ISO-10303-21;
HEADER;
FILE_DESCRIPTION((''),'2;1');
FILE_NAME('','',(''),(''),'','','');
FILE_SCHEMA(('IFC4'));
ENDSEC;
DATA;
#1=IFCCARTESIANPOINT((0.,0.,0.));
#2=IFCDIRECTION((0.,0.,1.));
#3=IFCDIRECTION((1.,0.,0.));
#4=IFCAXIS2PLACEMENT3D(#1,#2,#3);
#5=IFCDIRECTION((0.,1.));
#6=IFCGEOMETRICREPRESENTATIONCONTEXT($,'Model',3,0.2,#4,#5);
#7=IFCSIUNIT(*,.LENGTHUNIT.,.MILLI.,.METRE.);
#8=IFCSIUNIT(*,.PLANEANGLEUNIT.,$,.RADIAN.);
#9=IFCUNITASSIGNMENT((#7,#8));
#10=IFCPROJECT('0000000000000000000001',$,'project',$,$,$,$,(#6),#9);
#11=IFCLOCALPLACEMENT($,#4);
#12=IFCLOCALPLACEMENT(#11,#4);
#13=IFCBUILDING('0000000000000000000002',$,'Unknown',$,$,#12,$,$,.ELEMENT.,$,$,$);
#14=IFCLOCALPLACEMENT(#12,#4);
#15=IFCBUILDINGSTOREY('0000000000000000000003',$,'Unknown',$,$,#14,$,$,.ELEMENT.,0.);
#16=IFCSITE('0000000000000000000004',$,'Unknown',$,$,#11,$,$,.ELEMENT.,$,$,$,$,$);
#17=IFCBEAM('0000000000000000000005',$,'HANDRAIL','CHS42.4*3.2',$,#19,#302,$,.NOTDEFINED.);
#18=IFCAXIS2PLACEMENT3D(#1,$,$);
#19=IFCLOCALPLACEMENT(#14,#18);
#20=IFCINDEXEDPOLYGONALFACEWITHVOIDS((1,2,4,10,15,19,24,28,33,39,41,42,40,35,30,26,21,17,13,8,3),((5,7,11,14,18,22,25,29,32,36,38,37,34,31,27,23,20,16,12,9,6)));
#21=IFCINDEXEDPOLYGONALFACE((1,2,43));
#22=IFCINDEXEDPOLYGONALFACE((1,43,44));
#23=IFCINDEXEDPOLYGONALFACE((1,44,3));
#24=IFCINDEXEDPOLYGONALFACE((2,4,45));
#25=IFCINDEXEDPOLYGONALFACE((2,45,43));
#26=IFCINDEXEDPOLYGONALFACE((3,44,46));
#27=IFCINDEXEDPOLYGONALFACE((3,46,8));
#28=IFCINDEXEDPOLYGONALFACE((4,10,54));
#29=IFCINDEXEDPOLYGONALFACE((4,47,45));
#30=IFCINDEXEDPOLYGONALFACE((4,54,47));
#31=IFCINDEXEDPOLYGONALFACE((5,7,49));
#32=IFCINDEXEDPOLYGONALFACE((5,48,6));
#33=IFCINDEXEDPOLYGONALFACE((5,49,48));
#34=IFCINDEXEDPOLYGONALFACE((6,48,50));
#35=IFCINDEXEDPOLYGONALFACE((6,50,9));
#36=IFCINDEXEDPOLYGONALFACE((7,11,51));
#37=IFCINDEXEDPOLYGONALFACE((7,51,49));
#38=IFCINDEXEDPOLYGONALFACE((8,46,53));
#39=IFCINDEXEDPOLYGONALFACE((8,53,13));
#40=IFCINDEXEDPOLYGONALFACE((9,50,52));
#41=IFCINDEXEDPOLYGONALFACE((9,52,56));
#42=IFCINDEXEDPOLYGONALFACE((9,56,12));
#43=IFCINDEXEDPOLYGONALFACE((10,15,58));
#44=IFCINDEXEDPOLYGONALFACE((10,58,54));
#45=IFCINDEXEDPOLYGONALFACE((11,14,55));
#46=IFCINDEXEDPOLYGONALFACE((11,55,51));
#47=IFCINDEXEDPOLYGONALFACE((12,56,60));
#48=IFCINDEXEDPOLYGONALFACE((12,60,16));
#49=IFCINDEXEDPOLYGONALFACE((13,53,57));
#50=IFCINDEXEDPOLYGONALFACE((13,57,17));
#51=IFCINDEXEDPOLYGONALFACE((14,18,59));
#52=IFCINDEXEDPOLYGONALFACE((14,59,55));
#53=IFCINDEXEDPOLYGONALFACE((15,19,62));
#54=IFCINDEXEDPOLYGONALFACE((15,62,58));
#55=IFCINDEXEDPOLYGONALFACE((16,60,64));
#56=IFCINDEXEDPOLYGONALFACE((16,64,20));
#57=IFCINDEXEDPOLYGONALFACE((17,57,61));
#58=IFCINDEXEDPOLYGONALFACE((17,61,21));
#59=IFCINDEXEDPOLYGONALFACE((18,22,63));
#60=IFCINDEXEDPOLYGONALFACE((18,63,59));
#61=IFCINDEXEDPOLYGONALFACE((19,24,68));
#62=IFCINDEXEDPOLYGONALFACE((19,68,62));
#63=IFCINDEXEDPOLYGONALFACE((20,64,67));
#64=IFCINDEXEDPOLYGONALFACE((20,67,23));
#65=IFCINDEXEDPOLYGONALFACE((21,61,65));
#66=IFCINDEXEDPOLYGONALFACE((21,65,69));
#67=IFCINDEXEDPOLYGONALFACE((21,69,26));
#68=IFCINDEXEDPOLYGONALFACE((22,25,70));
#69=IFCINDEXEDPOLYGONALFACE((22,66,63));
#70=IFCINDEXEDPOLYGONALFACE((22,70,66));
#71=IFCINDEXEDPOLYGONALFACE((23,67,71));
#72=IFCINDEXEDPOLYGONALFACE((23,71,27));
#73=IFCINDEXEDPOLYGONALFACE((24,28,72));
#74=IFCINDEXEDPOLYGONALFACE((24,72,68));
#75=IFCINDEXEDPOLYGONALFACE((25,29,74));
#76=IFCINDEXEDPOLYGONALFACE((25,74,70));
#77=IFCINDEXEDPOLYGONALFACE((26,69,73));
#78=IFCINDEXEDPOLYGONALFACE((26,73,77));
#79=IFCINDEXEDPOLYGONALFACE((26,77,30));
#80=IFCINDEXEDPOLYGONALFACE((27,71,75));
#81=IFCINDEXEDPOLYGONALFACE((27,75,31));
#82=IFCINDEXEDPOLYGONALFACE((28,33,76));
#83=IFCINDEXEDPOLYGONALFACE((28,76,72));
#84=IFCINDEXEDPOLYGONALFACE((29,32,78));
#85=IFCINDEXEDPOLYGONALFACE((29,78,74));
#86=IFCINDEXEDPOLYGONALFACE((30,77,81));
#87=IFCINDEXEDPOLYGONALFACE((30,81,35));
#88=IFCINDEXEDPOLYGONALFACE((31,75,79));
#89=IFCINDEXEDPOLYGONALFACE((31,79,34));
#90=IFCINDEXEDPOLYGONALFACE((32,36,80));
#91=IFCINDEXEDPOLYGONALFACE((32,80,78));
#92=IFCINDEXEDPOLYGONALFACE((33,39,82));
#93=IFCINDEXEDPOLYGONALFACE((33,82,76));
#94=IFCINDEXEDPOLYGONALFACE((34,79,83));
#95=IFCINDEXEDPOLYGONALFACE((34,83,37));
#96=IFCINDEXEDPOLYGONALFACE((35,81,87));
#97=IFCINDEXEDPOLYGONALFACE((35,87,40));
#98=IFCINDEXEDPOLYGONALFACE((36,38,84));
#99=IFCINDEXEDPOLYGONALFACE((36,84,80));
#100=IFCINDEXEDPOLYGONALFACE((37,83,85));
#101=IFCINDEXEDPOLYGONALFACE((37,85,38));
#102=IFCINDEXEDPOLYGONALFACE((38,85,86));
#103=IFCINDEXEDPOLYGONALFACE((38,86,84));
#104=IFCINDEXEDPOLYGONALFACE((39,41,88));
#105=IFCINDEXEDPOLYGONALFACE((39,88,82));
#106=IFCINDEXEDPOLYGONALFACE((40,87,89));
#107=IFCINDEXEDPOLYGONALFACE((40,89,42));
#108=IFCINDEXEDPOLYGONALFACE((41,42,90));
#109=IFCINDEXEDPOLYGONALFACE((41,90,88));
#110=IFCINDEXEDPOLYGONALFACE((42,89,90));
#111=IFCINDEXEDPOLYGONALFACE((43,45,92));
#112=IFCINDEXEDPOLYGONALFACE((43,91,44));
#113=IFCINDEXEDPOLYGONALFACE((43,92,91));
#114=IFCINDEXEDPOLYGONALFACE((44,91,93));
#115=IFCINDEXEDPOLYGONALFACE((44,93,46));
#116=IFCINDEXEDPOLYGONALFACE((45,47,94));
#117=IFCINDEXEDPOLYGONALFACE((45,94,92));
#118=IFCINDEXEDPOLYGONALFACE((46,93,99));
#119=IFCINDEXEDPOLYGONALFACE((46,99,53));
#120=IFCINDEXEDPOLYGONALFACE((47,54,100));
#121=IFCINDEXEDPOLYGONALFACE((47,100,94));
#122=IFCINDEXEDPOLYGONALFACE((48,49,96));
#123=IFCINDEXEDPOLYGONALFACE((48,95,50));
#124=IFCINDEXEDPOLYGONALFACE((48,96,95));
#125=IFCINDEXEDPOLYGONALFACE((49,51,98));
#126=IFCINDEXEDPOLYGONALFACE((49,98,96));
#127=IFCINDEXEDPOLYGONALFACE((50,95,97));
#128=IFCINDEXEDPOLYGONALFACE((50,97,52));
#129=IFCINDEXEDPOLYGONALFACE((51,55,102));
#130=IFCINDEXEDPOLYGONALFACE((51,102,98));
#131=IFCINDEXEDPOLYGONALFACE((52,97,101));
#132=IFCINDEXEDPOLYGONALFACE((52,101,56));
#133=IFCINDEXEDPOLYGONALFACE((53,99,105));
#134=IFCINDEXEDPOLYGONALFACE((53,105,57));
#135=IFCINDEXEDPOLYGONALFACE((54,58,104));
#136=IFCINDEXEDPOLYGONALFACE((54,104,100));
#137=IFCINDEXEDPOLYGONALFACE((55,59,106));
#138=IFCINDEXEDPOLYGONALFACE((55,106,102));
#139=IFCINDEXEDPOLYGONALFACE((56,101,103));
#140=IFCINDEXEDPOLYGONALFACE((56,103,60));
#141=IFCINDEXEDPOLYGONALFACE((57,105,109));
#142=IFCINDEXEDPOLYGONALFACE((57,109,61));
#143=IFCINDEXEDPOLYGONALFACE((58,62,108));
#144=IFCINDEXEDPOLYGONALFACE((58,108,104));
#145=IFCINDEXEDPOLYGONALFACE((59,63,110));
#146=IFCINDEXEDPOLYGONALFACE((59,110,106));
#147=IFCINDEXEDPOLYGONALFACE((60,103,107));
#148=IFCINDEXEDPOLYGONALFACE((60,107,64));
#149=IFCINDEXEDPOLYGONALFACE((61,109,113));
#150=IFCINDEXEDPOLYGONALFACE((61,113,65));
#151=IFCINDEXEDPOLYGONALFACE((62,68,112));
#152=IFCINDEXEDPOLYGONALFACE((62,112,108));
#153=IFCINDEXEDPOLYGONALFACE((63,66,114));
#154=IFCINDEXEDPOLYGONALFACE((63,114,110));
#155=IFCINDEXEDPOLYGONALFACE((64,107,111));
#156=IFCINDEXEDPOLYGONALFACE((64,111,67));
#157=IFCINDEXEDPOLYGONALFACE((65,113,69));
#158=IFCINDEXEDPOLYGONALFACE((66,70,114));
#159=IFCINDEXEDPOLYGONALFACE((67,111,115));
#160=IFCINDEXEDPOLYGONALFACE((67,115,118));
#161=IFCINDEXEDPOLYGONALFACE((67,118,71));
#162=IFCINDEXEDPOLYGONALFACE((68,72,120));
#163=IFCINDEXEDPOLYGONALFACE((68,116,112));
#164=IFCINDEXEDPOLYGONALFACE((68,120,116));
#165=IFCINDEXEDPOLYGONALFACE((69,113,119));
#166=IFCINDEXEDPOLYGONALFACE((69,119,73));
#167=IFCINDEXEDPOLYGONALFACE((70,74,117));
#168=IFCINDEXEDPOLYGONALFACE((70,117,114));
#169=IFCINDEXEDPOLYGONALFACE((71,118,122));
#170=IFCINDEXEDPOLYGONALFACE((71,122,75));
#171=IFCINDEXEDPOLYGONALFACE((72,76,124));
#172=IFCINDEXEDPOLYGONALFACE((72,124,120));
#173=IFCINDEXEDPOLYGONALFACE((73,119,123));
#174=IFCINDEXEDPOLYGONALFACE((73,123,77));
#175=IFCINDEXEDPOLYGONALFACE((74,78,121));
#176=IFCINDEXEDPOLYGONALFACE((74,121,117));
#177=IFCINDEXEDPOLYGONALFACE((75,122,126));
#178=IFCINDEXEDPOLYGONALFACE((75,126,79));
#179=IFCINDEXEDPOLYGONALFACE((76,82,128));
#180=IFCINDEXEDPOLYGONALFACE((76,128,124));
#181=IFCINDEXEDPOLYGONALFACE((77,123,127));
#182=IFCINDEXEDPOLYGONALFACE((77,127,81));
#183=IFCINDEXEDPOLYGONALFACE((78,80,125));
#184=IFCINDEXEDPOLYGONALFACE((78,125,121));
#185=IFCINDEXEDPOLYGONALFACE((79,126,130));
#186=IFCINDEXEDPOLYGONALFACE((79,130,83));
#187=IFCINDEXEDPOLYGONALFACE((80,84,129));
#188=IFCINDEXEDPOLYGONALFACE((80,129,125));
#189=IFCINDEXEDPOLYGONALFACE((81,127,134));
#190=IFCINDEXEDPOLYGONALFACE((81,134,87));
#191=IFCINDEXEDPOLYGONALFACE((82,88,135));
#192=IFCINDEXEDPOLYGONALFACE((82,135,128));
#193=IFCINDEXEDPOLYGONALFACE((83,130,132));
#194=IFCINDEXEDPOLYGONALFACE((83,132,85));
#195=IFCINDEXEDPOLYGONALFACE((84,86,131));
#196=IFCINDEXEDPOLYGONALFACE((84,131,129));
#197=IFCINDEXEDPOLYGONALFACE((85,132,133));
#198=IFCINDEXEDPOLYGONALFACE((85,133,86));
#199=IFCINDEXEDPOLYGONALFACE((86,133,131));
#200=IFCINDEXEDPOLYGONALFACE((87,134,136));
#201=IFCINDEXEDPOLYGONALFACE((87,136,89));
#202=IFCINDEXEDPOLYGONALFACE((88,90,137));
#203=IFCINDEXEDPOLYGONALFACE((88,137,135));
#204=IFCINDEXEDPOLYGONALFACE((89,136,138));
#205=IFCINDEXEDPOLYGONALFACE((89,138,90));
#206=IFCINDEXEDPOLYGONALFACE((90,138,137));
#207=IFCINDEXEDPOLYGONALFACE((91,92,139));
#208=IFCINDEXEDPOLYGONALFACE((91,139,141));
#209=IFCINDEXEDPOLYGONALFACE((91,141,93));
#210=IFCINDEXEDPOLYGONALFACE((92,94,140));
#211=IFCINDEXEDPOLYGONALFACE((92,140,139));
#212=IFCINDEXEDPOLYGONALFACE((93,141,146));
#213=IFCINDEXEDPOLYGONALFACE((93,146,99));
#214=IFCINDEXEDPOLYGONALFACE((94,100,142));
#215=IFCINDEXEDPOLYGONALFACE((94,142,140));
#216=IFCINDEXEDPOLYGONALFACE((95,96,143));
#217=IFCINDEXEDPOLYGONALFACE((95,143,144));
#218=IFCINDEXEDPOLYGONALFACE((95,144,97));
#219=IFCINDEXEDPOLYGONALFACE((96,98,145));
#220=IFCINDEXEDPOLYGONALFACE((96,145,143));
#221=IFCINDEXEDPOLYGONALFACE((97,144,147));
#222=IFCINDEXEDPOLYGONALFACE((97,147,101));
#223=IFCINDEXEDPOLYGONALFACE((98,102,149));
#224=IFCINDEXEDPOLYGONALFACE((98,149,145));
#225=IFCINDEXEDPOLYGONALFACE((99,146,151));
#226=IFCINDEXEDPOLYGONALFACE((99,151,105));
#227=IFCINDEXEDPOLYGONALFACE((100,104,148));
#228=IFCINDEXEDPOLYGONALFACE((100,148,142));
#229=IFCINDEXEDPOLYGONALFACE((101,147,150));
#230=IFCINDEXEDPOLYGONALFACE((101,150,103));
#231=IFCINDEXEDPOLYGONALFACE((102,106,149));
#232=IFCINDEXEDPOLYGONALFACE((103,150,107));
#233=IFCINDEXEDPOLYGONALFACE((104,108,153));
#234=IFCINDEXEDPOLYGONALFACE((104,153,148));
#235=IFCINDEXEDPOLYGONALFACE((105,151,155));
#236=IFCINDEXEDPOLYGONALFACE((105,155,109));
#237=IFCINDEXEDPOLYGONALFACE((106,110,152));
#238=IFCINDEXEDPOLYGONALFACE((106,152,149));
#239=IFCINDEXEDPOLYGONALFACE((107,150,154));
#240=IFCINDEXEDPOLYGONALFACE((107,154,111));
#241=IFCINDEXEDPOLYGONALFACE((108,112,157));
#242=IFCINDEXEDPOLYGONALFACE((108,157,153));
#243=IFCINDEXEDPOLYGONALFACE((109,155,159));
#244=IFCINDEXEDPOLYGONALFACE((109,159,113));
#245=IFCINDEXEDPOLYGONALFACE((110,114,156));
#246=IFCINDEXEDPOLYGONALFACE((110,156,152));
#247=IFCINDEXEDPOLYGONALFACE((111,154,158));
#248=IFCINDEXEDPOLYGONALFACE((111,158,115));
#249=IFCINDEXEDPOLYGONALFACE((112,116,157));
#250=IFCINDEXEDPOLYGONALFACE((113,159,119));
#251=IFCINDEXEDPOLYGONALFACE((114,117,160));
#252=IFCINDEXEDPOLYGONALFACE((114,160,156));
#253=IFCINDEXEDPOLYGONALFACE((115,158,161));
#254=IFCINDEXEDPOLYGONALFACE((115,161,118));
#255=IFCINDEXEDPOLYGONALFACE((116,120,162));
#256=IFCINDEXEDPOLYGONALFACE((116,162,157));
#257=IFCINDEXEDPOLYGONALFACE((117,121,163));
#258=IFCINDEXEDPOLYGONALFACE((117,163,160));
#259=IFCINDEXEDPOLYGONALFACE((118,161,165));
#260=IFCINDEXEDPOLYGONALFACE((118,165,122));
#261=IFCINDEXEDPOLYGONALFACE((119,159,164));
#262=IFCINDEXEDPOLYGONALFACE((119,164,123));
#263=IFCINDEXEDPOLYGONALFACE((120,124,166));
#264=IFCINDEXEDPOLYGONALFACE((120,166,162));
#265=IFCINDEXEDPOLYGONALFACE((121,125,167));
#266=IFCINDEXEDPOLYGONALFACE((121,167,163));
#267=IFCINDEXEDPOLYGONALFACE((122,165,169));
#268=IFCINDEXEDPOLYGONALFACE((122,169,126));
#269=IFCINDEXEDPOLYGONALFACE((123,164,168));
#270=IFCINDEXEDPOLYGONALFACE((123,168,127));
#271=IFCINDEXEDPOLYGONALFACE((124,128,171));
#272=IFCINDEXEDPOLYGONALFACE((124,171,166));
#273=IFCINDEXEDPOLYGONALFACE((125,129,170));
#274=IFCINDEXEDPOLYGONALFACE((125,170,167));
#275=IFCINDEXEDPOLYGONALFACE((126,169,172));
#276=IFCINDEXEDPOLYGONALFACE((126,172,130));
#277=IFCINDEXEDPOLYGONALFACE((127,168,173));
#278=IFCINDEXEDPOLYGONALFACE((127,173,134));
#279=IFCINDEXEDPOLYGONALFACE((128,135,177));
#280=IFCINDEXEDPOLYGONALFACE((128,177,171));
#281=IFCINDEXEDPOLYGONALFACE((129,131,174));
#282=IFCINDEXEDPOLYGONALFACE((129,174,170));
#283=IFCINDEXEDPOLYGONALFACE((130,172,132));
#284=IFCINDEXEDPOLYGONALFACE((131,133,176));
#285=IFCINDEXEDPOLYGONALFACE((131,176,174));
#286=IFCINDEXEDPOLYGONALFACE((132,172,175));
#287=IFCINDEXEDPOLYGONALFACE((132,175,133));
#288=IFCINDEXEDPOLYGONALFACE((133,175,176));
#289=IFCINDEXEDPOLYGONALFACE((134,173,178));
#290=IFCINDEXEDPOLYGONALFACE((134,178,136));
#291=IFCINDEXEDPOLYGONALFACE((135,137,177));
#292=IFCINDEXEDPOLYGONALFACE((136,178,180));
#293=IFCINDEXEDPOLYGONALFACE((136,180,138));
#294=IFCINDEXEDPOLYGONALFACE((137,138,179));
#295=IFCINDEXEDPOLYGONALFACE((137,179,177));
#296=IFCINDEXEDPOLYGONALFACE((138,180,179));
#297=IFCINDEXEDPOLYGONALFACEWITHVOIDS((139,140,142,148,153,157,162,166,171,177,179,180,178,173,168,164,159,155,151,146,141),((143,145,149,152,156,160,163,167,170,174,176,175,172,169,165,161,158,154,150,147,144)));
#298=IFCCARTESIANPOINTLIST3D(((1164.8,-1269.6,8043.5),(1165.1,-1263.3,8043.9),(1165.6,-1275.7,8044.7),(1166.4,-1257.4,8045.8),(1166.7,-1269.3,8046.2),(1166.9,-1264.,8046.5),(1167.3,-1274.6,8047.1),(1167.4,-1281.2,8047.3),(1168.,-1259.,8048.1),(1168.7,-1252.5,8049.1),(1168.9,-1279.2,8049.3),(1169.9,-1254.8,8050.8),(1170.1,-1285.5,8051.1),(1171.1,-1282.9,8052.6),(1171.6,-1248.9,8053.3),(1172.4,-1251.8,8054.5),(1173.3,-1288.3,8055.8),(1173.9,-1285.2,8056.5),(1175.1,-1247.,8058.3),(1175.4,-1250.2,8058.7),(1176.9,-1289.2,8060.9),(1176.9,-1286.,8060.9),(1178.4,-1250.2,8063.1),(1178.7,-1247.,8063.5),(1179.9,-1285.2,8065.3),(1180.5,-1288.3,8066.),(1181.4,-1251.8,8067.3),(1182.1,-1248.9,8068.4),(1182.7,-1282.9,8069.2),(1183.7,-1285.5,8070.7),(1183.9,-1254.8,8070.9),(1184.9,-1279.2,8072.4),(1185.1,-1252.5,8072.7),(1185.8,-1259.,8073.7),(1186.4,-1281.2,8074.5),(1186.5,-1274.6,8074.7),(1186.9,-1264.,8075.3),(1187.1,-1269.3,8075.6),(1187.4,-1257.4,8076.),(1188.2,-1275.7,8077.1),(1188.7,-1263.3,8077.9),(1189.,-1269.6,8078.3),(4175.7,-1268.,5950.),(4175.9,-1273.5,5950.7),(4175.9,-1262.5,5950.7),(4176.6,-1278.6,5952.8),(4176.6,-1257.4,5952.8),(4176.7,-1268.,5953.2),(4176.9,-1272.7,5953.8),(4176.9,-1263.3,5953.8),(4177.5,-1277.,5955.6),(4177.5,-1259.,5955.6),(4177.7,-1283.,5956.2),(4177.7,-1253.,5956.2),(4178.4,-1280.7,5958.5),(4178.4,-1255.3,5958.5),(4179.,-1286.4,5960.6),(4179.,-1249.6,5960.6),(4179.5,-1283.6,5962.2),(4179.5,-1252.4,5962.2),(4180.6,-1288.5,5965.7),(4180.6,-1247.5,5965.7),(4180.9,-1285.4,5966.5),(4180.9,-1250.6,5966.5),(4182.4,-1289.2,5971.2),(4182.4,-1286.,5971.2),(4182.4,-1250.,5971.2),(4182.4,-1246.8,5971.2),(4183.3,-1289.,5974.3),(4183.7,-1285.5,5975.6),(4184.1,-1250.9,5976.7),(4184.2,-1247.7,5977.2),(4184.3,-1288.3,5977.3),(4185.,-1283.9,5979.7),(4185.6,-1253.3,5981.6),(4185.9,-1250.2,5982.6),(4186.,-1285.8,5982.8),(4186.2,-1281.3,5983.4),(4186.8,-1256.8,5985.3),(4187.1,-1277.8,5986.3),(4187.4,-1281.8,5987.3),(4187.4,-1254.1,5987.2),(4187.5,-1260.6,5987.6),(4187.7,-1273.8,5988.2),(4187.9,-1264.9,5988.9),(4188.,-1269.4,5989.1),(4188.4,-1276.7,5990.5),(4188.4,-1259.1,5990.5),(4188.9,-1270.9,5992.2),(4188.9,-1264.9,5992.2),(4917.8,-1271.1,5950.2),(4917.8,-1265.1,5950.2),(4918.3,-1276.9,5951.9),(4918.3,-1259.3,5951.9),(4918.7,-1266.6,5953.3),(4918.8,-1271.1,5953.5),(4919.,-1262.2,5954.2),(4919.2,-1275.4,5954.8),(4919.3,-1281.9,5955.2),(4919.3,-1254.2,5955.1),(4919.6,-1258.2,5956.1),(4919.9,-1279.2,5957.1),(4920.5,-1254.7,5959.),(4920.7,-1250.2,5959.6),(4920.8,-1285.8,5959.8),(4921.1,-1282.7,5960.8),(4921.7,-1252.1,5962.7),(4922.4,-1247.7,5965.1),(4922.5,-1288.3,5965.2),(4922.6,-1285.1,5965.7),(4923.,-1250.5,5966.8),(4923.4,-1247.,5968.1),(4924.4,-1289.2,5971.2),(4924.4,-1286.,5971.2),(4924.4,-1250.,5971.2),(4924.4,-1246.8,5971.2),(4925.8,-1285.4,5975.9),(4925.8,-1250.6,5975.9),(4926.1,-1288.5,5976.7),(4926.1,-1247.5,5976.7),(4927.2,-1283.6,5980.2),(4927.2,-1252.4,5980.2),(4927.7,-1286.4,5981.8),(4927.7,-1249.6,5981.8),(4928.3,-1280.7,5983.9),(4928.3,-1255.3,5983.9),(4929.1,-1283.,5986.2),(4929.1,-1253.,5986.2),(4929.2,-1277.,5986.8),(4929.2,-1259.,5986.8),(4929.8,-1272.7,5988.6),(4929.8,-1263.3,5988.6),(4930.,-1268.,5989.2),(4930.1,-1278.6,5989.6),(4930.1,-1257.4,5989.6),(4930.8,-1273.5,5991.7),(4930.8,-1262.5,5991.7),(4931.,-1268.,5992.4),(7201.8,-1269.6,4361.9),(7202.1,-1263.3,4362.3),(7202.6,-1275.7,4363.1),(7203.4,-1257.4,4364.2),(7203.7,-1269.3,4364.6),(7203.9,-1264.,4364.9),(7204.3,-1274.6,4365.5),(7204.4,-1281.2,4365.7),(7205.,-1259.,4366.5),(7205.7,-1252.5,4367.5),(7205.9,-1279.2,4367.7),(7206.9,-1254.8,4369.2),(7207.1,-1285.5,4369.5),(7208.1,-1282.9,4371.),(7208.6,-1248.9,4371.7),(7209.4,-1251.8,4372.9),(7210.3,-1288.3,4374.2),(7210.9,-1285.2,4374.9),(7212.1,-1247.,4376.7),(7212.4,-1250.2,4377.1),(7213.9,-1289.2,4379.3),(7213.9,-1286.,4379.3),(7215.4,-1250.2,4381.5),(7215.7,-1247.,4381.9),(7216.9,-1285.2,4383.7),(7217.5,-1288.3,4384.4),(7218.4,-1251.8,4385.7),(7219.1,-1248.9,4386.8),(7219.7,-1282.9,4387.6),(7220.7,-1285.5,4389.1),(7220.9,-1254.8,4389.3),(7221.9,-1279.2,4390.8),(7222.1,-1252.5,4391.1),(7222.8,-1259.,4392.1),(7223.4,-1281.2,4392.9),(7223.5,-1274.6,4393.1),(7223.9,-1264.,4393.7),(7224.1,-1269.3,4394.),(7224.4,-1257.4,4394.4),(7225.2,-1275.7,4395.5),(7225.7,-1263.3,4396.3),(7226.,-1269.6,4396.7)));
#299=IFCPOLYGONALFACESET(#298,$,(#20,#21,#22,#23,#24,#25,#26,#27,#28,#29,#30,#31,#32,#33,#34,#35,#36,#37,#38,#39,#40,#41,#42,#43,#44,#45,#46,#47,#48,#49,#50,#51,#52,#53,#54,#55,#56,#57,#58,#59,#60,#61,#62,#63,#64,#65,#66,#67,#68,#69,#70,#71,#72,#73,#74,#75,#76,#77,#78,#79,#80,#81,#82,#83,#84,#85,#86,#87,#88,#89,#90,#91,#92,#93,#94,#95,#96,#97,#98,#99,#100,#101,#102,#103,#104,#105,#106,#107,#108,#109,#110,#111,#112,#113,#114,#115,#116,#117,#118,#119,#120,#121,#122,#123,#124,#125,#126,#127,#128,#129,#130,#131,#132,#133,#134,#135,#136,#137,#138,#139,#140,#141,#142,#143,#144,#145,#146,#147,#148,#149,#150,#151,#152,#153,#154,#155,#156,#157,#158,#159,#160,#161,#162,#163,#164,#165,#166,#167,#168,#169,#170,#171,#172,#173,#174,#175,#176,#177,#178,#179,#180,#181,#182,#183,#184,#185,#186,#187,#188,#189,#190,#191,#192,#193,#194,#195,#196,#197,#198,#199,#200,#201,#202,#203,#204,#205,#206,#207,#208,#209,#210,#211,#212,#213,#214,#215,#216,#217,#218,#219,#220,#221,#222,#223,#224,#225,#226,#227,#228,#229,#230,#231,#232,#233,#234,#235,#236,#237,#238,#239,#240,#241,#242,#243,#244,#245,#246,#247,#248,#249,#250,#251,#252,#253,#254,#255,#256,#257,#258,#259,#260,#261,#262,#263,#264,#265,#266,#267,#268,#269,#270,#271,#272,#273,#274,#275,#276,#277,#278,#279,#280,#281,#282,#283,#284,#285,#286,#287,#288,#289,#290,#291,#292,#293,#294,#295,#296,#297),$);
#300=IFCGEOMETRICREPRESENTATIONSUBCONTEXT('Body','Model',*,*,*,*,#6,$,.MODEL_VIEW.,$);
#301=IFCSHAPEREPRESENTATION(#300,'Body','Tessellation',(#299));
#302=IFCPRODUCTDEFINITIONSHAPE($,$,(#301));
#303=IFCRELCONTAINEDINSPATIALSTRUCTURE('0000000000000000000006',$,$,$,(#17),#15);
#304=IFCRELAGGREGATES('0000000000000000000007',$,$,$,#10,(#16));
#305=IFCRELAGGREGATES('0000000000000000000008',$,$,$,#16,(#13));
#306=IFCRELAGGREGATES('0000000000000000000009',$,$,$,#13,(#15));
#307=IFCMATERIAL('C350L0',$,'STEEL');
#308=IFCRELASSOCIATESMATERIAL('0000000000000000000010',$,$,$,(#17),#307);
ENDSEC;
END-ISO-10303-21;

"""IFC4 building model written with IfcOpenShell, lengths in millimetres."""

from ifc_helpers import new_model, entity, si_unit, direction, frame, origin_with_axes, place, context, subcontext, project, spatial, material, element, save


model = new_model("IFC4")

# Units and contexts
model_context = context("Model", 3, precision=0.2, world=origin_with_axes(), true_north=direction((0.0, 1.0)))
body_context = subcontext(model_context, "Body", "Model", "MODEL_VIEW")
ifc_project = project(units=[si_unit("LENGTHUNIT", "METRE", prefix="MILLI"), si_unit("PLANEANGLEUNIT", "RADIAN")], contexts=[model_context])

# Site, building, storey
site_placement = place(None, origin_with_axes())
site = spatial("IfcSite", under=ifc_project, at=site_placement, Name="Unknown", CompositionType="ELEMENT")
building_placement = place(site_placement, origin_with_axes())
building = spatial("IfcBuilding", under=site, at=building_placement, Name="Unknown", CompositionType="ELEMENT")
storey_placement = place(building_placement, origin_with_axes())
storey = spatial("IfcBuildingStorey", under=building, at=storey_placement, Name="Unknown", CompositionType="ELEMENT", Elevation=0.0)

# Shared definitions
ifc_material_1 = material(Name="C350L0", Category="STEEL")

# Beam
for number, where, z_axis, x_axis, name in (
    (1, (1176.9, -1268.0, 8060.9), (0.0, -1.0, 0.0), (0.821041, 0.0, -0.57087), "HANDRAIL"),
):
    element("IfcBeam", number, at=place(storey_placement, frame(where, z_axis=z_axis, x_axis=x_axis)), inside=storey, material=ifc_material_1, Name=name, Description="CHS42.4*3.2", PredefinedType="NOTDEFINED", context=body_context, shape_type="SolidModel", body=[
        entity("IfcSweptDiskSolid", entity("IfcIndexedPolyCurve", entity("IfcCartesianPointList3D", [[0.0, 0.0, 0.0], [3660.5, 0.0, 0.0], [4269.8, 423.6, 0.0], [7058.3, 423.6, 0.0]]), [entity("IfcLineIndex", [1, 2, 3, 4])]), 21.2, 18.0),
    ])

save(model, "model.ifc")
